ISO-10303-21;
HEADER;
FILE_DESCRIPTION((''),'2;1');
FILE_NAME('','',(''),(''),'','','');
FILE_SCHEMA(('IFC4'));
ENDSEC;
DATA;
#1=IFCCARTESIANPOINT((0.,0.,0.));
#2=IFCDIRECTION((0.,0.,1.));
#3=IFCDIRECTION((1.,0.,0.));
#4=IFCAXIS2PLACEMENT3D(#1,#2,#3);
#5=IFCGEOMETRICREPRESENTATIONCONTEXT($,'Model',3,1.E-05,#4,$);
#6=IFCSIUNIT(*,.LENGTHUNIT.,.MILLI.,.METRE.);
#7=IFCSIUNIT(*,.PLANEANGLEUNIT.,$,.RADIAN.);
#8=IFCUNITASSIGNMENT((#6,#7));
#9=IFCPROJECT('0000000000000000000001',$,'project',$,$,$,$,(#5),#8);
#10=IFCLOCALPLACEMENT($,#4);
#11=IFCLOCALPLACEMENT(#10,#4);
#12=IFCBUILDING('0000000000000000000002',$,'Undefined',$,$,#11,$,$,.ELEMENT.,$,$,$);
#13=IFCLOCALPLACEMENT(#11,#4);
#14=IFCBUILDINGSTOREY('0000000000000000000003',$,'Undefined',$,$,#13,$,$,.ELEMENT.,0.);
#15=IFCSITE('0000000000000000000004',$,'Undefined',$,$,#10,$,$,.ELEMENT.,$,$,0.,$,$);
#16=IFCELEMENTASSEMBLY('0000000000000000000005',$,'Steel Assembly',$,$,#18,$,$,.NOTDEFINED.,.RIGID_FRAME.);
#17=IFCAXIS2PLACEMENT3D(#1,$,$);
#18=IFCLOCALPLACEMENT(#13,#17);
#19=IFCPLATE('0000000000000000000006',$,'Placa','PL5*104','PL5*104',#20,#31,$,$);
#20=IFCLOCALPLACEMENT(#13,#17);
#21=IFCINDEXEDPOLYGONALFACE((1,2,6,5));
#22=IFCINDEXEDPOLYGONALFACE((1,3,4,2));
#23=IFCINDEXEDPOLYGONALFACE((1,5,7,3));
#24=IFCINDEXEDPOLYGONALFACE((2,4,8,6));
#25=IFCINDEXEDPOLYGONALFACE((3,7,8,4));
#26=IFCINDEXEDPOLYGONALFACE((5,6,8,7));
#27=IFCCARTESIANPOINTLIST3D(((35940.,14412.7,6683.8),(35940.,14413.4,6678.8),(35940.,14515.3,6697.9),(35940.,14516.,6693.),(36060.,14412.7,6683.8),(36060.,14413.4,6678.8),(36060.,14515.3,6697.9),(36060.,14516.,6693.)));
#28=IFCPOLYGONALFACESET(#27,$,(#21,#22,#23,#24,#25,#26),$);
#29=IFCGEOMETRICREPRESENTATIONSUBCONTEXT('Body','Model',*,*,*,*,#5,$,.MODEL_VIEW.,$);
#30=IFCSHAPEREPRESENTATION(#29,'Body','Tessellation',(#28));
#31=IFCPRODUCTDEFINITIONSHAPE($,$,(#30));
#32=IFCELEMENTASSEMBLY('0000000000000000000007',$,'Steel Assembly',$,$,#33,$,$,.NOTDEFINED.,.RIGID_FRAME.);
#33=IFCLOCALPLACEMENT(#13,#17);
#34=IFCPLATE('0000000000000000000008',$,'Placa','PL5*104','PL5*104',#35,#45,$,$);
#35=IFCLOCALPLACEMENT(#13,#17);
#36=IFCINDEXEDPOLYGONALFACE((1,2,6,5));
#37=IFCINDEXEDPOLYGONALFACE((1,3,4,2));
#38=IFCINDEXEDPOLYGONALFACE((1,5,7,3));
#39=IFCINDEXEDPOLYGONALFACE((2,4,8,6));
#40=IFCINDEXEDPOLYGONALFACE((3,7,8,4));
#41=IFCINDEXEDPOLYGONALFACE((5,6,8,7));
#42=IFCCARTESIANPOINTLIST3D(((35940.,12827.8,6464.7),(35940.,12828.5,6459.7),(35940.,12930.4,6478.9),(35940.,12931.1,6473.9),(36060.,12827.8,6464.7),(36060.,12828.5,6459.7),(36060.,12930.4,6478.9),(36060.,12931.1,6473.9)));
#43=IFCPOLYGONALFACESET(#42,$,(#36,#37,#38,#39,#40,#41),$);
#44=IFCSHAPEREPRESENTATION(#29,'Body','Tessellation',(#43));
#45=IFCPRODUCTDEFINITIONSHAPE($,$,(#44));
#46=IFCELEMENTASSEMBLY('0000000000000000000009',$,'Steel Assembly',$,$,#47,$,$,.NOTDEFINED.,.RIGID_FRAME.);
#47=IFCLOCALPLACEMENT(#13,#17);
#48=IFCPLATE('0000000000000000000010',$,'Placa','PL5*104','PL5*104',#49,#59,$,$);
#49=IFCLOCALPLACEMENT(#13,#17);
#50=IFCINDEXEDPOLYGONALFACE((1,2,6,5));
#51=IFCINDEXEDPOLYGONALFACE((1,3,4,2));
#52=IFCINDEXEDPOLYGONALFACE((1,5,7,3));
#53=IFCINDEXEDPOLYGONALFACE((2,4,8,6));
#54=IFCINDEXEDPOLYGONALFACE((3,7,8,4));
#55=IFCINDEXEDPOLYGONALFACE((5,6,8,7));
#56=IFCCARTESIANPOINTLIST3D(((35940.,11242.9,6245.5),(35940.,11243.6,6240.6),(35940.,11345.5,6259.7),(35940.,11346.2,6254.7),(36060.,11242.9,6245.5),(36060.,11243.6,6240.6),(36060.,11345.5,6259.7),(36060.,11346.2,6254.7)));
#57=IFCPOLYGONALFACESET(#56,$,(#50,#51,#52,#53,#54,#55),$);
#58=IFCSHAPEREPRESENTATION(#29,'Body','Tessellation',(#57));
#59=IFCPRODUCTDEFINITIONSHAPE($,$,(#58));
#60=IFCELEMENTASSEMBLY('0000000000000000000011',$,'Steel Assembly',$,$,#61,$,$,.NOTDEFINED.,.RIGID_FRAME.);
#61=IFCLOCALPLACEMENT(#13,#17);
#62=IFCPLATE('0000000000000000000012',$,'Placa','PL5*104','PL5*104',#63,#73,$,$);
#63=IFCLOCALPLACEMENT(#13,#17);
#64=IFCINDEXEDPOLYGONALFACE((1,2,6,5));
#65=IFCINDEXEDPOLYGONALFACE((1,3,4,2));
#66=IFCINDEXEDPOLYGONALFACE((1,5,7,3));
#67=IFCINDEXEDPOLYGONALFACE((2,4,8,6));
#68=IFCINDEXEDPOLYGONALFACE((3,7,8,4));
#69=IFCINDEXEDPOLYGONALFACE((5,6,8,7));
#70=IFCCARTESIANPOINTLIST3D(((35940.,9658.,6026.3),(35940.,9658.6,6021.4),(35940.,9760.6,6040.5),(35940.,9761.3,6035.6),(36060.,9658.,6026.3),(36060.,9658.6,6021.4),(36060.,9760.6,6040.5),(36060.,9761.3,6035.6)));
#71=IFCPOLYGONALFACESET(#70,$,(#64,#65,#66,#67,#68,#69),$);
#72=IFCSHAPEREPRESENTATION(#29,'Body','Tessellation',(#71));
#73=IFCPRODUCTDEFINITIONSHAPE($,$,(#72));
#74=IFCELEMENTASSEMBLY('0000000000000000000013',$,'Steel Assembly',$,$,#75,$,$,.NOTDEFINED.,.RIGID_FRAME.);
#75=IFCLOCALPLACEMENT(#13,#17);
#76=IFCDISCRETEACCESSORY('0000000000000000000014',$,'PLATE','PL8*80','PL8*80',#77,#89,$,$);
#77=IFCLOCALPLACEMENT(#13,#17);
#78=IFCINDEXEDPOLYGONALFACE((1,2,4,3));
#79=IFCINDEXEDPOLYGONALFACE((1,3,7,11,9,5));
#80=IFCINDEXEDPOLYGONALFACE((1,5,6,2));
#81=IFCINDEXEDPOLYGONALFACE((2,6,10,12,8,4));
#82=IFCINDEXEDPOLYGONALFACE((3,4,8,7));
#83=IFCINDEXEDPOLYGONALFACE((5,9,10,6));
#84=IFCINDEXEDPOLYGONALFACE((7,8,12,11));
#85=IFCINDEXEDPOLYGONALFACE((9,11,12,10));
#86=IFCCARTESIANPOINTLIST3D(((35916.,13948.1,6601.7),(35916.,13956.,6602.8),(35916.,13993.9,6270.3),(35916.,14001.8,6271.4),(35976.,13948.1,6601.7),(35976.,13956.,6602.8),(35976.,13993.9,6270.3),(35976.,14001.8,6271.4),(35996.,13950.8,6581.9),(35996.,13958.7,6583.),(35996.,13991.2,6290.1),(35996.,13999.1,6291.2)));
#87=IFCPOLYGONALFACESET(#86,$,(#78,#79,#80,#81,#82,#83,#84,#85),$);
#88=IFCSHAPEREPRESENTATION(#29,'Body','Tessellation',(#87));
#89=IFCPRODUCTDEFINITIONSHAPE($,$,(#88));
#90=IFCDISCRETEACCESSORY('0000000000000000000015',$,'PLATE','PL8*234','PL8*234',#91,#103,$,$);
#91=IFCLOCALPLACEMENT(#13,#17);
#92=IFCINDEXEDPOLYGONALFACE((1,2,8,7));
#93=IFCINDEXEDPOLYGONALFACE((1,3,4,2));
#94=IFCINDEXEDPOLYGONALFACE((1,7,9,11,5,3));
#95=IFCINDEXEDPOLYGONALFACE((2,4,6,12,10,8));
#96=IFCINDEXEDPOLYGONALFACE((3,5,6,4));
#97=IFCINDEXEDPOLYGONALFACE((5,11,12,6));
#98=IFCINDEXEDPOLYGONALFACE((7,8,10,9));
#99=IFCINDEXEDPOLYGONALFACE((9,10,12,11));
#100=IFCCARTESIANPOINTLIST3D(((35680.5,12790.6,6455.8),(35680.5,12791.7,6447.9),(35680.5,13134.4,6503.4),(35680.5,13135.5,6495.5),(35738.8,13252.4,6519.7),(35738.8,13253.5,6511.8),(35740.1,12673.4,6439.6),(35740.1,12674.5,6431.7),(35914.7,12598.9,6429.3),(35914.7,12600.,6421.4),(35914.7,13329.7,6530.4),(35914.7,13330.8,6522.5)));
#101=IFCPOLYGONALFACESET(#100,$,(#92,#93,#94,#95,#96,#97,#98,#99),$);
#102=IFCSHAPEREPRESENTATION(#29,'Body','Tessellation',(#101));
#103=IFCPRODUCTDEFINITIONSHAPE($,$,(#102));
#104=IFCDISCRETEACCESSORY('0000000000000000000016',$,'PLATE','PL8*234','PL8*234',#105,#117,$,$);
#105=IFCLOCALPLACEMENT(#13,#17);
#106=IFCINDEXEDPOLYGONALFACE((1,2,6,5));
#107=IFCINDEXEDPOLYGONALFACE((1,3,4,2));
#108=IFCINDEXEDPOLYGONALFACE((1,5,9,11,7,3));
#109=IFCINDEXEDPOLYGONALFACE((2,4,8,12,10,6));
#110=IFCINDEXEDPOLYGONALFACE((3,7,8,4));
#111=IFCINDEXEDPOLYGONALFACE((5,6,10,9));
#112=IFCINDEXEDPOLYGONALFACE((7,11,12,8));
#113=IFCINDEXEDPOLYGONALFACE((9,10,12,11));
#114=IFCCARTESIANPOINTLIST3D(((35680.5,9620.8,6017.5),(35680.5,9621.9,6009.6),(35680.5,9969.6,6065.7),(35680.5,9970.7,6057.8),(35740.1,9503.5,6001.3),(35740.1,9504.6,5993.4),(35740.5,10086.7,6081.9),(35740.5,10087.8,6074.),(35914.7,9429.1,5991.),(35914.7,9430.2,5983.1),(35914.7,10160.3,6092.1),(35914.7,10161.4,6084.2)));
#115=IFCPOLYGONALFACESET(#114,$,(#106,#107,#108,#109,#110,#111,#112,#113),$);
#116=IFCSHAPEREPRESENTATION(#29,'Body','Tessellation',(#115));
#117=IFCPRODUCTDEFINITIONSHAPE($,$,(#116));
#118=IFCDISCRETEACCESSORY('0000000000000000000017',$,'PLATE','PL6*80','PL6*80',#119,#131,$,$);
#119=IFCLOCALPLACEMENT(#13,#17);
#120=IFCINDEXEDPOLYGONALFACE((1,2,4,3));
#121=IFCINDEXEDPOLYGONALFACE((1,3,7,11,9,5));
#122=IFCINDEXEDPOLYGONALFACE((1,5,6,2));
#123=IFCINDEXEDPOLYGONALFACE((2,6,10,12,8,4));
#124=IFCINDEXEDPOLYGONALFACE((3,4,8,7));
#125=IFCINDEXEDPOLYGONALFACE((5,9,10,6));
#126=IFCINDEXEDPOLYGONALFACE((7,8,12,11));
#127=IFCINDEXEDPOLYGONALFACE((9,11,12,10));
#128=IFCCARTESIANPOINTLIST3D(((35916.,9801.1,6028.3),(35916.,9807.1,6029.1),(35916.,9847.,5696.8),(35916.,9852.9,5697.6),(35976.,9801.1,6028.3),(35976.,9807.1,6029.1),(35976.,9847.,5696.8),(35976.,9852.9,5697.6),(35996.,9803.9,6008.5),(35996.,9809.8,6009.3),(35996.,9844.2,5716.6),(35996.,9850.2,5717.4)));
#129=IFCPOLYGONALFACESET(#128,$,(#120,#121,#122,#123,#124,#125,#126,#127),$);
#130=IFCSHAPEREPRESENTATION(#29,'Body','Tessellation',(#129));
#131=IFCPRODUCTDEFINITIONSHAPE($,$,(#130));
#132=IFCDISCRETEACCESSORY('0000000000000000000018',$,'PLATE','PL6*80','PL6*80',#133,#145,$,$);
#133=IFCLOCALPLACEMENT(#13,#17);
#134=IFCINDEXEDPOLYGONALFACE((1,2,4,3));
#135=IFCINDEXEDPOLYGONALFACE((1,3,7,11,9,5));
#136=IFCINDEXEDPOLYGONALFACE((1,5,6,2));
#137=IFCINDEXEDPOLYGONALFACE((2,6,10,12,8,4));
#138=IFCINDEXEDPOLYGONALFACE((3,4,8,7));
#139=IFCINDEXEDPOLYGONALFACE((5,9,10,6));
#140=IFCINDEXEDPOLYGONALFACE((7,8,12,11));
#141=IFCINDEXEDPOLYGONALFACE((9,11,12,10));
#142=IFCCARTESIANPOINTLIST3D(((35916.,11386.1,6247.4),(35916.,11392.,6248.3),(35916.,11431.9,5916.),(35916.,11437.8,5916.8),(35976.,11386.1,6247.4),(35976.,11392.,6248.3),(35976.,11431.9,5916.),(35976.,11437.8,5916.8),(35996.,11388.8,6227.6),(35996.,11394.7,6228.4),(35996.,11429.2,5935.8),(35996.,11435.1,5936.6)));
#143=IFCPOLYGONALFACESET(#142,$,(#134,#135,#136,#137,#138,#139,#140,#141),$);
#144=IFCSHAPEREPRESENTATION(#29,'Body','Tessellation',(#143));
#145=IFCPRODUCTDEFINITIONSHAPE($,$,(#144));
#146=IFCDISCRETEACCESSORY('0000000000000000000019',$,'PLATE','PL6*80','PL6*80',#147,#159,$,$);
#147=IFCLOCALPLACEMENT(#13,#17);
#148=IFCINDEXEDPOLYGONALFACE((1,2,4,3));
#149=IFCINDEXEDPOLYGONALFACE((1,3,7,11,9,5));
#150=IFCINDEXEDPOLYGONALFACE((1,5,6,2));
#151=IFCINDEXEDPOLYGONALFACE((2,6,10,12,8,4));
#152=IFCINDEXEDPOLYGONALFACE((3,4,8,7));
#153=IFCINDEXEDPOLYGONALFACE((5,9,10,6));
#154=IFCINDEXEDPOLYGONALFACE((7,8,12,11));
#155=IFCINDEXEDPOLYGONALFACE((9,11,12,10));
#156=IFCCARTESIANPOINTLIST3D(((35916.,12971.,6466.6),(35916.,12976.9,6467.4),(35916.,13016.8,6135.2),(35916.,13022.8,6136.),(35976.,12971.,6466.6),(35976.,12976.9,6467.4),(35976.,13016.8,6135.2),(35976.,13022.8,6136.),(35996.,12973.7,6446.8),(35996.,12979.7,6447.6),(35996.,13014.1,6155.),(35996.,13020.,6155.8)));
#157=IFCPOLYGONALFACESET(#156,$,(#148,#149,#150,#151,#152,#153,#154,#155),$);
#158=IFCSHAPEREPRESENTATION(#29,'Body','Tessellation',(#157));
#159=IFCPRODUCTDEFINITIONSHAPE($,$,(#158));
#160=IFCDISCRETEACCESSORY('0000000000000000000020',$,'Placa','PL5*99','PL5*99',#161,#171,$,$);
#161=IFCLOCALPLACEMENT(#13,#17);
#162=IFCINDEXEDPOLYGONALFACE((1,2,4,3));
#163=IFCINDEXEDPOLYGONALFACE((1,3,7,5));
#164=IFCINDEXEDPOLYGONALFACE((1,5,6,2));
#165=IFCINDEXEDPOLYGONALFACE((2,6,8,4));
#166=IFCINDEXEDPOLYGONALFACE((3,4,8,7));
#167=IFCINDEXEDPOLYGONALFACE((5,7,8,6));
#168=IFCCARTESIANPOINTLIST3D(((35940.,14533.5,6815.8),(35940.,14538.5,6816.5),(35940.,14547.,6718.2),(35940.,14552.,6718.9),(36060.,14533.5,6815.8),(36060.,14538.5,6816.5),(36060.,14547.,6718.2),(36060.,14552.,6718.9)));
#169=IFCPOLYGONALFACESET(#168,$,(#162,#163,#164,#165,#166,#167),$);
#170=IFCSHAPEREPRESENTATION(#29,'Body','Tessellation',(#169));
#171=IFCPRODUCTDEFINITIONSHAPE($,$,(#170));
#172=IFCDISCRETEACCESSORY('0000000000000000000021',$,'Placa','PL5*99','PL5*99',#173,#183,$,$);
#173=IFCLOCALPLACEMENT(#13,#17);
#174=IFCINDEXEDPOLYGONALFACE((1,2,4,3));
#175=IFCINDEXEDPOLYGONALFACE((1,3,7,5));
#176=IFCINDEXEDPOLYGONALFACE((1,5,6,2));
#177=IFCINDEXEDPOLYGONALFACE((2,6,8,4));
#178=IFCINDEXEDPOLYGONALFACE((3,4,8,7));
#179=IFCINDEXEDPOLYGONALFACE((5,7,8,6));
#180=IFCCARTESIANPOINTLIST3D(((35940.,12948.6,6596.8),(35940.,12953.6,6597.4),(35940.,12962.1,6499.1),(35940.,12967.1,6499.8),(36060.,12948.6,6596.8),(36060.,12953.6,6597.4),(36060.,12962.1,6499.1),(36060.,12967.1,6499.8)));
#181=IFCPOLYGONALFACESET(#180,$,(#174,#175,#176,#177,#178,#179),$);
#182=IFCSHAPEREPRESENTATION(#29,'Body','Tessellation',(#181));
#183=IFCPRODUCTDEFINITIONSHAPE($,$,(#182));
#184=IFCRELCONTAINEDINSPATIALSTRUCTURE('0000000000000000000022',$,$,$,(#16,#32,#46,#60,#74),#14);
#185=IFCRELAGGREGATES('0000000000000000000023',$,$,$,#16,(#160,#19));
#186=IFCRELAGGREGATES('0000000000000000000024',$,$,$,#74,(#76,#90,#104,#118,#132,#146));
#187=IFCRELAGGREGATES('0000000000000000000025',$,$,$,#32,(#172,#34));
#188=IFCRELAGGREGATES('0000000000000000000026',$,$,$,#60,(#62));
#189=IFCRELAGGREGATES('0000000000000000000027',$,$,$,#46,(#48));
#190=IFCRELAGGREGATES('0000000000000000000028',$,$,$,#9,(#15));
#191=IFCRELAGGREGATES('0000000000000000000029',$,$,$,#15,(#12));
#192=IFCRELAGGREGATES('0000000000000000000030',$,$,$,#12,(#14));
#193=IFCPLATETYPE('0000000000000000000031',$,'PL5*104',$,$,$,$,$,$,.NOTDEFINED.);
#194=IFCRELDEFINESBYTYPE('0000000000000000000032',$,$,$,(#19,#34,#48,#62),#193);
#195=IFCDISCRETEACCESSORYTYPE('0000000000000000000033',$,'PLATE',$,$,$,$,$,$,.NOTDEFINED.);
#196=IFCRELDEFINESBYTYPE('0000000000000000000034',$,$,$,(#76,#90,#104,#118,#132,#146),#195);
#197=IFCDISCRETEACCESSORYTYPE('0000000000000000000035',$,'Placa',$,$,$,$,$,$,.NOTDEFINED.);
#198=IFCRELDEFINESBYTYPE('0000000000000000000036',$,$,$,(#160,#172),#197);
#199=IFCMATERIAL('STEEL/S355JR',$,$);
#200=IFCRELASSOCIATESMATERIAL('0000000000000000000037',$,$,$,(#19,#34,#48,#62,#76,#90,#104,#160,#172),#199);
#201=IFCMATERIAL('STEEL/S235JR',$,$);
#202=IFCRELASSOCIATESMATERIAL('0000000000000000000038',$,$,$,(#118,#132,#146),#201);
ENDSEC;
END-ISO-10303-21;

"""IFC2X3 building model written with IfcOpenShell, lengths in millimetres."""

from ifc_helpers import new_model, si_unit, frame, origin_with_axes, place, context, subcontext, project, spatial, polyline, outline, extrude, material, type_object, element, aggregate, save


model = new_model("IFC2X3")

# Units and contexts
model_context = context("Model", 3, precision=1e-05, world=origin_with_axes())
body_context = subcontext(model_context, "Body", "Model", "MODEL_VIEW")
ifc_project = project(units=[si_unit("LENGTHUNIT", "METRE", prefix="MILLI"), si_unit("PLANEANGLEUNIT", "RADIAN")], contexts=[model_context])

# Site, building, storey
site_placement = place(None, origin_with_axes())
site = spatial("IfcSite", under=ifc_project, at=site_placement, Name="Undefined", CompositionType="ELEMENT", RefElevation=0.0)
building_placement = place(site_placement, origin_with_axes())
building = spatial("IfcBuilding", under=site, at=building_placement, Name="Undefined", CompositionType="ELEMENT")
storey_placement = place(building_placement, origin_with_axes())
storey = spatial("IfcBuildingStorey", under=building, at=storey_placement, Name="Undefined", CompositionType="ELEMENT", Elevation=0.0)

# Shared definitions
ifc_material_1 = material(Name="STEEL/S355JR")

# Element assemblies, plates
assembly_1_placement = place(storey_placement, origin_with_axes())
assembly_1 = element("IfcElementAssembly", 1, at=assembly_1_placement, inside=storey, Name="Steel Assembly", AssemblyPlace="NOTDEFINED", PredefinedType="RIGID_FRAME")
plate_type_1 = type_object("IfcPlateType", Name="PL5*104", PredefinedType="NOTDEFINED")
plate_1_placement = place(assembly_1_placement, frame((35940.0, 14515.7, 6695.5), z_axis=(0.0, -0.136905, 0.990584), x_axis=(0.0, -0.990584, -0.136905)))
plate_1 = element("IfcPlate", 2, at=plate_1_placement, type_object=plate_type_1, material=ifc_material_1, Name="Placa", Description="PL5*104", ObjectType="PL5*104", context=body_context, shape_type="SweptSolid", body=[
    extrude(outline(polyline([(0.0, 0.0), (103.6, 0.0), (103.6, 120.0), (0.0, 120.0), (0.0, 0.0)])), frame((0.0, 0.0, -2.5), z_axis=(0.0, 0.0, 1.0), x_axis=(1.0, 0.0, 0.0)), (0.0, 0.0, 1.0), 5.0),
])
assembly_2_placement = place(storey_placement, origin_with_axes())
assembly_2 = element("IfcElementAssembly", 3, at=assembly_2_placement, inside=storey, Name="Steel Assembly", AssemblyPlace="NOTDEFINED", PredefinedType="RIGID_FRAME")
plate_2_placement = place(assembly_2_placement, frame((35940.0, 12930.8, 6476.4), z_axis=(0.0, -0.136905, 0.990584), x_axis=(0.0, -0.990584, -0.136905)))
plate_2 = element("IfcPlate", 4, at=plate_2_placement, type_object=plate_type_1, material=ifc_material_1, Name="Placa", Description="PL5*104", ObjectType="PL5*104", context=body_context, shape_type="SweptSolid", body=[
    extrude(outline(polyline([(0.0, 0.0), (103.6, 0.0), (103.6, 120.0), (0.0, 120.0), (0.0, 0.0)])), frame((0.0, 0.0, -2.5), z_axis=(0.0, 0.0, 1.0), x_axis=(1.0, 0.0, 0.0)), (0.0, 0.0, 1.0), 5.0),
])
assembly_3_placement = place(storey_placement, origin_with_axes())
assembly_3 = element("IfcElementAssembly", 5, at=assembly_3_placement, inside=storey, Name="Steel Assembly", AssemblyPlace="NOTDEFINED", PredefinedType="RIGID_FRAME")
plate_3_placement = place(assembly_3_placement, frame((35940.0, 11345.8, 6257.2), z_axis=(0.0, -0.136905, 0.990584), x_axis=(0.0, -0.990584, -0.136905)))
plate_3 = element("IfcPlate", 6, at=plate_3_placement, type_object=plate_type_1, material=ifc_material_1, Name="Placa", Description="PL5*104", ObjectType="PL5*104", context=body_context, shape_type="SweptSolid", body=[
    extrude(outline(polyline([(0.0, 0.0), (103.6, 0.0), (103.6, 120.0), (0.0, 120.0), (0.0, 0.0)])), frame((0.0, 0.0, -2.5), z_axis=(0.0, 0.0, 1.0), x_axis=(1.0, 0.0, 0.0)), (0.0, 0.0, 1.0), 5.0),
])
assembly_4_placement = place(storey_placement, origin_with_axes())
assembly_4 = element("IfcElementAssembly", 7, at=assembly_4_placement, inside=storey, Name="Steel Assembly", AssemblyPlace="NOTDEFINED", PredefinedType="RIGID_FRAME")
plate_4_placement = place(assembly_4_placement, frame((35940.0, 9760.9, 6038.0), z_axis=(0.0, -0.136905, 0.990584), x_axis=(0.0, -0.990584, -0.136905)))
plate_4 = element("IfcPlate", 8, at=plate_4_placement, type_object=plate_type_1, material=ifc_material_1, Name="Placa", Description="PL5*104", ObjectType="PL5*104", context=body_context, shape_type="SweptSolid", body=[
    extrude(outline(polyline([(0.0, 0.0), (103.6, 0.0), (103.6, 120.0), (0.0, 120.0), (0.0, 0.0)])), frame((0.0, 0.0, -2.5), z_axis=(0.0, 0.0, 1.0), x_axis=(1.0, 0.0, 0.0)), (0.0, 0.0, 1.0), 5.0),
])

# Element assembly, discrete accessories
assembly_5_placement = place(storey_placement, origin_with_axes())
assembly_5 = element("IfcElementAssembly", 9, at=assembly_5_placement, inside=storey, Name="Steel Assembly", AssemblyPlace="NOTDEFINED", PredefinedType="RIGID_FRAME")
discrete_accessory_type_1 = type_object("IfcDiscreteAccessoryType", Name="PLATE")
discrete_accessory_1_placement = place(assembly_5_placement, frame((35996.0, 13997.9, 6270.8), z_axis=(0.0, 0.990574, 0.13698), x_axis=(-1.0, 0.0, 0.0)))
discrete_accessory_1 = element("IfcDiscreteAccessory", 10, at=discrete_accessory_1_placement, type_object=discrete_accessory_type_1, material=ifc_material_1, Name="PLATE", Description="PL8*80", ObjectType="PL8*80", context=body_context, shape_type="SweptSolid", body=[
    extrude(outline(polyline([(0.0, 20.0), (20.0, 0.0), (80.0, 0.0), (80.0, 334.6), (20.0, 334.6), (0.0, 314.6), (0.0, 20.0)])), frame((0.0, 0.0, -4.0), z_axis=(0.0, 0.0, 1.0), x_axis=(1.0, 0.0, 0.0)), (0.0, 0.0, 1.0), 8.0),
])
discrete_accessory_2_placement = place(assembly_5_placement, frame((35914.7, 12599.5, 6425.4), z_axis=(-0.000018, -0.13698, 0.990574), x_axis=(0.0, 0.990574, 0.13698)))
discrete_accessory_2 = element("IfcDiscreteAccessory", 11, at=discrete_accessory_2_placement, type_object=discrete_accessory_type_1, material=ifc_material_1, Name="PLATE", Description="PL8*234", ObjectType="PL8*234", context=body_context, shape_type="SweptSolid", body=[
    extrude(outline(polyline([(0.0, 0.0), (737.8, 0.0), (659.7, 175.9), (540.6, 234.3), (193.6, 234.3), (75.2, 174.6), (0.0, 0.0)])), frame((0.0, 0.0, -4.0), z_axis=(0.0, 0.0, 1.0), x_axis=(1.0, 0.0, 0.0)), (0.0, 0.0, 1.0), 8.0),
])
discrete_accessory_3_placement = place(assembly_5_placement, frame((35914.7, 9429.6, 5987.0), z_axis=(-0.000018, -0.13698, 0.990574), x_axis=(0.0, 0.990574, 0.13698)))
discrete_accessory_3 = element("IfcDiscreteAccessory", 12, at=discrete_accessory_3_placement, type_object=discrete_accessory_type_1, material=ifc_material_1, Name="PLATE", Description="PL8*234", ObjectType="PL8*234", context=body_context, shape_type="SweptSolid", body=[
    extrude(outline(polyline([(0.0, 0.0), (738.2, 0.0), (663.9, 174.2), (545.6, 234.3), (193.6, 234.3), (75.2, 174.6), (0.0, 0.0)])), frame((0.0, 0.0, -4.0), z_axis=(0.0, 0.0, 1.0), x_axis=(1.0, 0.0, 0.0)), (0.0, 0.0, 1.0), 8.0),
])
ifc_material_2 = material(Name="STEEL/S235JR")
discrete_accessory_4_placement = place(assembly_5_placement, frame((35996.0, 9850.0, 5697.2), z_axis=(0.0, 0.990574, 0.13698), x_axis=(-1.0, 0.0, 0.0)))
discrete_accessory_4 = element("IfcDiscreteAccessory", 13, at=discrete_accessory_4_placement, type_object=discrete_accessory_type_1, material=ifc_material_2, Name="PLATE", Description="PL6*80", ObjectType="PL6*80", context=body_context, shape_type="SweptSolid", body=[
    extrude(outline(polyline([(0.0, 20.0), (20.0, 0.0), (80.0, 0.0), (80.0, 334.6), (20.0, 334.6), (0.0, 314.6), (0.0, 20.0)])), frame((0.0, 0.0, -3.0), z_axis=(0.0, 0.0, 1.0), x_axis=(1.0, 0.0, 0.0)), (0.0, 0.0, 1.0), 6.0),
])
discrete_accessory_5_placement = place(assembly_5_placement, frame((35996.0, 11434.9, 5916.4), z_axis=(0.0, 0.990574, 0.13698), x_axis=(-1.0, 0.0, 0.0)))
discrete_accessory_5 = element("IfcDiscreteAccessory", 14, at=discrete_accessory_5_placement, type_object=discrete_accessory_type_1, material=ifc_material_2, Name="PLATE", Description="PL6*80", ObjectType="PL6*80", context=body_context, shape_type="SweptSolid", body=[
    extrude(outline(polyline([(0.0, 20.0), (20.0, 0.0), (80.0, 0.0), (80.0, 334.6), (20.0, 334.6), (0.0, 314.6), (0.0, 20.0)])), frame((0.0, 0.0, -3.0), z_axis=(0.0, 0.0, 1.0), x_axis=(1.0, 0.0, 0.0)), (0.0, 0.0, 1.0), 6.0),
])
discrete_accessory_6_placement = place(assembly_5_placement, frame((35996.0, 13019.8, 6135.6), z_axis=(0.0, 0.990574, 0.13698), x_axis=(-1.0, 0.0, 0.0)))
discrete_accessory_6 = element("IfcDiscreteAccessory", 15, at=discrete_accessory_6_placement, type_object=discrete_accessory_type_1, material=ifc_material_2, Name="PLATE", Description="PL6*80", ObjectType="PL6*80", context=body_context, shape_type="SweptSolid", body=[
    extrude(outline(polyline([(0.0, 20.0), (20.0, 0.0), (80.0, 0.0), (80.0, 334.6), (20.0, 334.6), (0.0, 314.6), (0.0, 20.0)])), frame((0.0, 0.0, -3.0), z_axis=(0.0, 0.0, 1.0), x_axis=(1.0, 0.0, 0.0)), (0.0, 0.0, 1.0), 6.0),
])

# Discrete accessories
discrete_accessory_type_2 = type_object("IfcDiscreteAccessoryType", Name="Placa")
discrete_accessory_7_placement = place(assembly_1_placement, frame((35940.0, 14549.5, 6718.5), z_axis=(0.0, 0.990592, 0.136849), x_axis=(0.0, -0.136849, 0.990592)))
discrete_accessory_7 = element("IfcDiscreteAccessory", 16, at=discrete_accessory_7_placement, type_object=discrete_accessory_type_2, material=ifc_material_1, Name="Placa", Description="PL5*99", ObjectType="PL5*99", context=body_context, shape_type="SweptSolid", body=[
    extrude(outline(polyline([(0.0, 0.0), (98.6, 0.0), (98.6, 120.0), (0.0, 120.0), (0.0, 0.0)])), frame((0.0, 0.0, -2.5), z_axis=(0.0, 0.0, 1.0), x_axis=(1.0, 0.0, 0.0)), (0.0, 0.0, 1.0), 5.0),
])
aggregate(assembly_1, [discrete_accessory_7, plate_1])
discrete_accessory_8_placement = place(assembly_2_placement, frame((35940.0, 12964.6, 6499.4), z_axis=(0.0, 0.990592, 0.136849), x_axis=(0.0, -0.136849, 0.990592)))
discrete_accessory_8 = element("IfcDiscreteAccessory", 17, at=discrete_accessory_8_placement, type_object=discrete_accessory_type_2, material=ifc_material_1, Name="Placa", Description="PL5*99", ObjectType="PL5*99", context=body_context, shape_type="SweptSolid", body=[
    extrude(outline(polyline([(0.0, 0.0), (98.6, 0.0), (98.6, 120.0), (0.0, 120.0), (0.0, 0.0)])), frame((0.0, 0.0, -2.5), z_axis=(0.0, 0.0, 1.0), x_axis=(1.0, 0.0, 0.0)), (0.0, 0.0, 1.0), 5.0),
])
aggregate(assembly_5, [discrete_accessory_1, discrete_accessory_2, discrete_accessory_3, discrete_accessory_4, discrete_accessory_5, discrete_accessory_6])

aggregate(assembly_2, [discrete_accessory_8, plate_2])

aggregate(assembly_4, [plate_4])
aggregate(assembly_3, [plate_3])

save(model, "model.ifc")
